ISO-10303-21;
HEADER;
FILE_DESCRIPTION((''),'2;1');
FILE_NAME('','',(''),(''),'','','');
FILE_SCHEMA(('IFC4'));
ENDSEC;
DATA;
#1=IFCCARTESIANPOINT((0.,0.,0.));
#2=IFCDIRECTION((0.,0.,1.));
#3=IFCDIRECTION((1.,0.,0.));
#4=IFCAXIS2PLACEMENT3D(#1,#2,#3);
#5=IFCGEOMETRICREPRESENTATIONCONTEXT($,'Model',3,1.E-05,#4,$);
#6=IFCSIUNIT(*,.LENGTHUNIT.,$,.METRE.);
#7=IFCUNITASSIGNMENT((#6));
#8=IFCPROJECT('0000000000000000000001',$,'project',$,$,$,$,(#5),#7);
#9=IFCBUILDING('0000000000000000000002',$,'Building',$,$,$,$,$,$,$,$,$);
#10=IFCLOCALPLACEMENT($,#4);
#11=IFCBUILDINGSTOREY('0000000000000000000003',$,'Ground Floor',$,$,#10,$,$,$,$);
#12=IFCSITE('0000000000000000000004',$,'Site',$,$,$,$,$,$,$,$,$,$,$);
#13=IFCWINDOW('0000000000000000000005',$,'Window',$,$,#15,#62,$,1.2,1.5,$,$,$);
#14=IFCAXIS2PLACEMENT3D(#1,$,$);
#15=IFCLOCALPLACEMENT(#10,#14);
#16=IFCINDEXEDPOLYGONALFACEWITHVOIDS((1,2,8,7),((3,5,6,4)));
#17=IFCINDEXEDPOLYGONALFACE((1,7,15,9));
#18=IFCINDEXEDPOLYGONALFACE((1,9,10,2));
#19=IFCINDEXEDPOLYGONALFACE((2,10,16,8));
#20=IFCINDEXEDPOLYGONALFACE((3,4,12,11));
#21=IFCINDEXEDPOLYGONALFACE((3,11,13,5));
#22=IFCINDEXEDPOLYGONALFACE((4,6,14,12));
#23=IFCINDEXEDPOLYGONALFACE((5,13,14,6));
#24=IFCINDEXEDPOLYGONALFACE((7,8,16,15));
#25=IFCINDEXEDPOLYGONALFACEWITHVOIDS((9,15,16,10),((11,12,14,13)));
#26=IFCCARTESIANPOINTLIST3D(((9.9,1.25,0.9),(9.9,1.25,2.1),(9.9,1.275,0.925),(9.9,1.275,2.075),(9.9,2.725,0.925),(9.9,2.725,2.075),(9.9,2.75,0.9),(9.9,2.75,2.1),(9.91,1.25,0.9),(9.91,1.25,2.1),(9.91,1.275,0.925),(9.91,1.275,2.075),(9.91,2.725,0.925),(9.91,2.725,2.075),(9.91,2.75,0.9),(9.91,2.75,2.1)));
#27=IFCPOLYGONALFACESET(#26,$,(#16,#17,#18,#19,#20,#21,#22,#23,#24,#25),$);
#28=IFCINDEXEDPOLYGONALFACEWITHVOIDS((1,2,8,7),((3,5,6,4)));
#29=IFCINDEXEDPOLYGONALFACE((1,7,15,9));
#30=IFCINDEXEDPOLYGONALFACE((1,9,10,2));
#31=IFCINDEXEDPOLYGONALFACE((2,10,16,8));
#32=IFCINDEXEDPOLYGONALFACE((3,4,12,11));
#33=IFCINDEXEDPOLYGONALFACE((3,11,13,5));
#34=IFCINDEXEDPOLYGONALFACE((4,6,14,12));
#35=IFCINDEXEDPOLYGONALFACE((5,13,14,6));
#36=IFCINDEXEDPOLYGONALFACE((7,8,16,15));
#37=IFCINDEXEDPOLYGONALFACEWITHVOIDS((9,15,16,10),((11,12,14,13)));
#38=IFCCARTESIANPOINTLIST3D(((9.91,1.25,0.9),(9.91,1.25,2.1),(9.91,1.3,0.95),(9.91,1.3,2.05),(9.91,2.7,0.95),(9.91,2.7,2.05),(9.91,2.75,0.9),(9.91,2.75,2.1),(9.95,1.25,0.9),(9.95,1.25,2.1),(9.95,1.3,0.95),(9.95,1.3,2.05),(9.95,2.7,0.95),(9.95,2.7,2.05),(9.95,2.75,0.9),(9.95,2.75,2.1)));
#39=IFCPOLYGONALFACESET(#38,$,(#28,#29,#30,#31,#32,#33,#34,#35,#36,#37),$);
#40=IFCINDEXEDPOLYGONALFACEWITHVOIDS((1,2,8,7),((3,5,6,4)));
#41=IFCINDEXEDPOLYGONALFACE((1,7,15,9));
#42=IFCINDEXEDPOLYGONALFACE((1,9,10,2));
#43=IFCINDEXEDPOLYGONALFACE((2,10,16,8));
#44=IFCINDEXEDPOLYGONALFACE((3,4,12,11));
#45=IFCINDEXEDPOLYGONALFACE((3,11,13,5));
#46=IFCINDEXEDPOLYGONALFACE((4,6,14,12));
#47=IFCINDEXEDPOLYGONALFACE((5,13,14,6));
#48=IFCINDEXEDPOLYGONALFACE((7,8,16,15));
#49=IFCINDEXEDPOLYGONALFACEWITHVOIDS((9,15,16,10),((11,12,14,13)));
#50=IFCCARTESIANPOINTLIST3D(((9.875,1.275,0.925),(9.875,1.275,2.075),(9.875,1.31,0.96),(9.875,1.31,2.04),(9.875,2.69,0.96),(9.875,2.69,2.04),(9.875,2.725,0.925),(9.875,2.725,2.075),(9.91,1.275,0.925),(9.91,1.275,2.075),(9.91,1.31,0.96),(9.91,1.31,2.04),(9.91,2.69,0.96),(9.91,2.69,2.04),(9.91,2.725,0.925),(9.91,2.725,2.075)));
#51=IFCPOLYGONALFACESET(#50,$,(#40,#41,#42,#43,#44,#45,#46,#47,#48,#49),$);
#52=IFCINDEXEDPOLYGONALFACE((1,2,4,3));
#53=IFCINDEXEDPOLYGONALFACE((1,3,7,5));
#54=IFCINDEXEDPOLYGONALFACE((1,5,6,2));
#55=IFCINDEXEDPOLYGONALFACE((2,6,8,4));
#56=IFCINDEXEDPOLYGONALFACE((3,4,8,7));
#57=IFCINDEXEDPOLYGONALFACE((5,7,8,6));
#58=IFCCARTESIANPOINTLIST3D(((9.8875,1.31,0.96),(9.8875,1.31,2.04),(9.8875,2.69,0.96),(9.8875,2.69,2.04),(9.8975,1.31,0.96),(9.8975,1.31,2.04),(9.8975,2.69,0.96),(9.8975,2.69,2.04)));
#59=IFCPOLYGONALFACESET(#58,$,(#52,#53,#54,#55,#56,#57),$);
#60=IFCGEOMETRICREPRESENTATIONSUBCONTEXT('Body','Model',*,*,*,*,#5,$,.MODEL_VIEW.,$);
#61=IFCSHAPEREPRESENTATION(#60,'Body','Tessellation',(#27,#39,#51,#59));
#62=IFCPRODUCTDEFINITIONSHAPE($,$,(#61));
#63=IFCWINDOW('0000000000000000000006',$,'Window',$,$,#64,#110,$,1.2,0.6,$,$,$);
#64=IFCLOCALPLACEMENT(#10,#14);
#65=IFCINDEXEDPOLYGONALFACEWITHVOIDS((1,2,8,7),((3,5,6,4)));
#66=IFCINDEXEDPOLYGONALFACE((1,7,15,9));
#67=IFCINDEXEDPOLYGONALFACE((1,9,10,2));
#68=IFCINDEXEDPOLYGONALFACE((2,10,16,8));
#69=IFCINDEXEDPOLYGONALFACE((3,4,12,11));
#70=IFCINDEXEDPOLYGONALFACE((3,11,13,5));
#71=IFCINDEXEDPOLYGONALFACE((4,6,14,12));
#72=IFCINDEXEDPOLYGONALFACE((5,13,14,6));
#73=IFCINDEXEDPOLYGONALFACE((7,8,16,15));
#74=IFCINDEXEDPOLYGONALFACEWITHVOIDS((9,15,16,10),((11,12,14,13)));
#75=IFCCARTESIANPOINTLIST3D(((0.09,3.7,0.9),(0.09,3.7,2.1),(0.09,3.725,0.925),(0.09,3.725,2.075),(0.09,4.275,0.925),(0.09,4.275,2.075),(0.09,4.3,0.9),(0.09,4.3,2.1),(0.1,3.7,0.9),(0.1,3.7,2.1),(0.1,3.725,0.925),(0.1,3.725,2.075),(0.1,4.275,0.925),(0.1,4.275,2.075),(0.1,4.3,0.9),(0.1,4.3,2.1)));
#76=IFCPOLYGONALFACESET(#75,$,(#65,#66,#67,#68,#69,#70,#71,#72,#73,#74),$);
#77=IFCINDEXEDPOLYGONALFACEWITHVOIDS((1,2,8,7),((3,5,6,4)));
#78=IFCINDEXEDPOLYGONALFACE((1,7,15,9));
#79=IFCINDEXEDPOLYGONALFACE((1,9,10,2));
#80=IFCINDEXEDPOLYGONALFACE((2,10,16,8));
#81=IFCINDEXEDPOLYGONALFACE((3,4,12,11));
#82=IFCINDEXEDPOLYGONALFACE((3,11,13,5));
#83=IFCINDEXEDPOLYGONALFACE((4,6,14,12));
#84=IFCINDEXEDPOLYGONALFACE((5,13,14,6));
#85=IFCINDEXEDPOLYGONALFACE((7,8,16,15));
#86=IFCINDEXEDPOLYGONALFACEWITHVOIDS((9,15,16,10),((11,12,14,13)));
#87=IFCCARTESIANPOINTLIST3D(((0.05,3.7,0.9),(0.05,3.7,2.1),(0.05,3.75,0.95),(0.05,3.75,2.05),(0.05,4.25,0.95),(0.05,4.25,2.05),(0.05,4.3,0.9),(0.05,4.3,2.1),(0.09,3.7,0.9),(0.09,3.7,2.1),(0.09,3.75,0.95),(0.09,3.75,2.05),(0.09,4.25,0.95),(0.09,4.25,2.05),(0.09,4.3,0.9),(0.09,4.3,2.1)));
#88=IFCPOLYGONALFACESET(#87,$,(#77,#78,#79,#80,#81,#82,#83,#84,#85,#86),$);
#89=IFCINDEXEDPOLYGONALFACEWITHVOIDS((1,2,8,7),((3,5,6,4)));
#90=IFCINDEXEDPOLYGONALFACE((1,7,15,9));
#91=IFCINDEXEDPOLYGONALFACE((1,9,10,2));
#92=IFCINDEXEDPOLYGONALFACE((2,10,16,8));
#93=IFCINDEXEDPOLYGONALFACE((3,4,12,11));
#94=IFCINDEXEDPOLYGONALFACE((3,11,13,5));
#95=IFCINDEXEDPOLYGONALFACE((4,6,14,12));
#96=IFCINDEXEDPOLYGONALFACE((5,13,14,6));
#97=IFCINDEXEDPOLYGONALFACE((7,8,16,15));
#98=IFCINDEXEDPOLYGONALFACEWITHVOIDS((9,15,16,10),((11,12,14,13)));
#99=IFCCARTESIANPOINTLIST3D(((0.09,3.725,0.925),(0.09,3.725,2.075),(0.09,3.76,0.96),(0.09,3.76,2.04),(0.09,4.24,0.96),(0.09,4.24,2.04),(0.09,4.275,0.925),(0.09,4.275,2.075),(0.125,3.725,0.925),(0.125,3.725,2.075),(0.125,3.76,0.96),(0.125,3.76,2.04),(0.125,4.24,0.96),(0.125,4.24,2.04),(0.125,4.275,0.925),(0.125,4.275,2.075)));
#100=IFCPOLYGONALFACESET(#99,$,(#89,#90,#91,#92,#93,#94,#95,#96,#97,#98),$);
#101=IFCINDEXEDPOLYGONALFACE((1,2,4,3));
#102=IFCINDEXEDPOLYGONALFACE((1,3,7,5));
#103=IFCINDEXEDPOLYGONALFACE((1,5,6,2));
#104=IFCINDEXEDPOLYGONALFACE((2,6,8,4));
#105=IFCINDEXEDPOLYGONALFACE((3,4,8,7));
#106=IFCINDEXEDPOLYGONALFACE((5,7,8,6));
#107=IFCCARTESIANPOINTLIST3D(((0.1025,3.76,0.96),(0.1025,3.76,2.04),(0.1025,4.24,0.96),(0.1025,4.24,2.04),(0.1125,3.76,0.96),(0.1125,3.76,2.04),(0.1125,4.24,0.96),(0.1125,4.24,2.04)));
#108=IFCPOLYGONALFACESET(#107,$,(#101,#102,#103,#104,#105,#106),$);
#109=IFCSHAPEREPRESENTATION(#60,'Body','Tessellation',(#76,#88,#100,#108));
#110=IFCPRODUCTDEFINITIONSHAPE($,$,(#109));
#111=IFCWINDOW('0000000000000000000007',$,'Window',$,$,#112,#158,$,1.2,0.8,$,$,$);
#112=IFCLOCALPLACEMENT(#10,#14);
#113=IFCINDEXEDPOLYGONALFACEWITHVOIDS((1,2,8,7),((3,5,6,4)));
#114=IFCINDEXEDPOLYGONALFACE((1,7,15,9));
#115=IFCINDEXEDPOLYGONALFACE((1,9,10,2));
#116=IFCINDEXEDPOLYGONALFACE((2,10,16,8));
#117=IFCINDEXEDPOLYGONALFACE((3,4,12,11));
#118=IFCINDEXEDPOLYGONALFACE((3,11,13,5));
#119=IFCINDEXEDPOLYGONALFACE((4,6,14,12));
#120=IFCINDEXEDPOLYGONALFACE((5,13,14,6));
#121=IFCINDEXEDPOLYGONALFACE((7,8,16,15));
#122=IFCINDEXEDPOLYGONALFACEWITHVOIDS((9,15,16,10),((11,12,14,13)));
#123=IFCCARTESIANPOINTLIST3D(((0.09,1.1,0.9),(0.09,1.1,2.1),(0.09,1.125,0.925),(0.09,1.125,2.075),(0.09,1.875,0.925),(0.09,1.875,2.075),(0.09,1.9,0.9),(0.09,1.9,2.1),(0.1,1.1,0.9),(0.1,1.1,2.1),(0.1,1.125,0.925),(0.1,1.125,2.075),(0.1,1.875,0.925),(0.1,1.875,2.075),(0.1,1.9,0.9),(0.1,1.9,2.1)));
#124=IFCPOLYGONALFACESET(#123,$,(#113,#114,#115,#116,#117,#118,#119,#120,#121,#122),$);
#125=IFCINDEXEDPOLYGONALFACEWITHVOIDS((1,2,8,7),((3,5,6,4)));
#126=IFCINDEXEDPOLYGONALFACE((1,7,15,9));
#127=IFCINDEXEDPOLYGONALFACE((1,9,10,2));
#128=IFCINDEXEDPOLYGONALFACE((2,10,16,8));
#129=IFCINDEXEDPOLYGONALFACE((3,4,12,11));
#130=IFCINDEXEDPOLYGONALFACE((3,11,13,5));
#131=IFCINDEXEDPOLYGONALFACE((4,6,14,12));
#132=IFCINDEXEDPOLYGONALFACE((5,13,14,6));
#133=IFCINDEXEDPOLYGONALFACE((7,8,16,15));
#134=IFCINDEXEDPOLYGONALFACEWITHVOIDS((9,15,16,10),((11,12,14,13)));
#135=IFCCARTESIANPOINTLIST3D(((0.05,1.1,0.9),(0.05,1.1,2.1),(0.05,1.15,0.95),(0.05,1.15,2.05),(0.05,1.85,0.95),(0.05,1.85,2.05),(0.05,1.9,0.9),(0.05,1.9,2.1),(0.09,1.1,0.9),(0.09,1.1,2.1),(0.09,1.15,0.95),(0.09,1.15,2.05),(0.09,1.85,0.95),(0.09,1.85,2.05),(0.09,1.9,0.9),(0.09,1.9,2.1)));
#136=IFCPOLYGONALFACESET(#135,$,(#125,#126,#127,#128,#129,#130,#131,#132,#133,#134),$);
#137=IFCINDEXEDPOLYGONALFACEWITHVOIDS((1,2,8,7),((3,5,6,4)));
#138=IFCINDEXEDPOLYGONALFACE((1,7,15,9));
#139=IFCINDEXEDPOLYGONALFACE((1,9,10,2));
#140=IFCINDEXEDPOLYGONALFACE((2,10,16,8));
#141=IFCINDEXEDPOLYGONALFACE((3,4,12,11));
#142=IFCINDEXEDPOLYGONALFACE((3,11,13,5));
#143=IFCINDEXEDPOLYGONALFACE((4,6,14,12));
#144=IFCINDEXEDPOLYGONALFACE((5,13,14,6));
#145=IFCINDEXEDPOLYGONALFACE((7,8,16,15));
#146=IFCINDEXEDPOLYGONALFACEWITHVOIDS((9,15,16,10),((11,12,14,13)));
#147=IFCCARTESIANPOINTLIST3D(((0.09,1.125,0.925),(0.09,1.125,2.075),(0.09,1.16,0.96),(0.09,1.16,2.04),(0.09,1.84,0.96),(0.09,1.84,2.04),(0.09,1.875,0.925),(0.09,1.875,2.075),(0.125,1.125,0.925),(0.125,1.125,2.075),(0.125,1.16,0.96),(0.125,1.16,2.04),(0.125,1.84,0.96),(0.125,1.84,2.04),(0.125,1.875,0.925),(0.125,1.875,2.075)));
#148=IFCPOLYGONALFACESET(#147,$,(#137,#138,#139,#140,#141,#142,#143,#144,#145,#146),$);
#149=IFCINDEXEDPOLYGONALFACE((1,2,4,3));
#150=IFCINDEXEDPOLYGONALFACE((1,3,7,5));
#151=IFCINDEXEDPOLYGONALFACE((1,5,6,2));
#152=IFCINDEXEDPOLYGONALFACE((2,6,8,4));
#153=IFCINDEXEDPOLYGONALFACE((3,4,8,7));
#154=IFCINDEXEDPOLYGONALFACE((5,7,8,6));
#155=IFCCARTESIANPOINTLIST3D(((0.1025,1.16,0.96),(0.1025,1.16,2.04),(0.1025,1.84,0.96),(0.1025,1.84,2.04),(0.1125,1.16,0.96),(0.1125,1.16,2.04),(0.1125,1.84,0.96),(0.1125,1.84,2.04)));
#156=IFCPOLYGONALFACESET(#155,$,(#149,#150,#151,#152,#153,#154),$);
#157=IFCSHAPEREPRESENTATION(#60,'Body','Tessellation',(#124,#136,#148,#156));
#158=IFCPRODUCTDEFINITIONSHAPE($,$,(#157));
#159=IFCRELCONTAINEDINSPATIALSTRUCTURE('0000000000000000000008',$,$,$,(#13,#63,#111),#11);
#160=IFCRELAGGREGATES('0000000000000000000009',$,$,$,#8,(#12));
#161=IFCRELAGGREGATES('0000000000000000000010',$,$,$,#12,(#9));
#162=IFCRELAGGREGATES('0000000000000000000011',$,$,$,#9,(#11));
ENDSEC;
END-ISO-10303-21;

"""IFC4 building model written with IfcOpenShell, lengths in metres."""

from ifc_helpers import new_model, si_unit, frame, origin_with_axes, place, context, subcontext, project, spatial, line, indexed_curve, outline, extrude, element, save


model = new_model("IFC4")

# Units and contexts
model_context = context("Model", 3, precision=1e-05, world=origin_with_axes())
body_context = subcontext(model_context, "Body", "Model", "MODEL_VIEW")
ifc_project = project(units=[si_unit("LENGTHUNIT", "METRE")], contexts=[model_context])

# Site, building, storey
site = spatial("IfcSite", under=ifc_project, Name="Site")
building = spatial("IfcBuilding", under=site, Name="Building")
storey_placement = place(None, origin_with_axes())
storey = spatial("IfcBuildingStorey", under=building, at=storey_placement, Name="Ground Floor")

# Windows
window_1_placement = place(storey_placement, frame((10.0, 1.25, 0.9), z_axis=(0.0, 0.0, 1.0), x_axis=(0.0, 1.0, 0.0)))
element("IfcWindow", 1, at=window_1_placement, inside=storey, Name="Window", OverallHeight=1.2, OverallWidth=1.5, context=body_context, shape_type="SweptSolid", body=[
    extrude(outline(indexed_curve([(0.0, 0.0), (1.5, 0.0), (1.5, 1.2), (0.0, 1.2)], segments=[line(1, 2, 3, 4, 1)]), holes=[indexed_curve([(0.025, 0.025), (1.475, 0.025), (1.475, 1.175), (0.025, 1.175)], segments=[line(1, 2, 3, 4, 1)])]), frame((0.0, 0.09, 0.0), z_axis=(0.0, -1.0, 0.0), x_axis=(1.0, 0.0, 0.0)), (0.0, 0.0, -1.0), 0.01),
    extrude(outline(indexed_curve([(0.0, 0.0), (1.5, 0.0), (1.5, 1.2), (0.0, 1.2)], segments=[line(1, 2, 3, 4, 1)]), holes=[indexed_curve([(0.05, 0.05), (1.45, 0.05), (1.45, 1.15), (0.05, 1.15)], segments=[line(1, 2, 3, 4, 1)])]), frame((0.0, 0.05, 0.0), z_axis=(0.0, -1.0, 0.0), x_axis=(1.0, 0.0, 0.0)), (0.0, 0.0, -1.0), 0.04),
    extrude(outline(indexed_curve([(0.0, 0.0), (1.45, 0.0), (1.45, 1.15), (0.0, 1.15)], segments=[line(1, 2, 3, 4, 1)]), holes=[indexed_curve([(0.035, 0.035), (1.415, 0.035), (1.415, 1.115), (0.035, 1.115)], segments=[line(1, 2, 3, 4, 1)])]), frame((0.025, 0.09, 0.025), z_axis=(0.0, -1.0, 0.0), x_axis=(1.0, 0.0, 0.0)), (0.0, 0.0, -1.0), 0.035),
    extrude(outline(indexed_curve([(0.035, 0.035), (1.415, 0.035), (1.415, 1.115), (0.035, 1.115)], segments=[line(1, 2, 3, 4, 1)])), frame((0.025, 0.1025, 0.025), z_axis=(0.0, -1.0, 0.0), x_axis=(1.0, 0.0, 0.0)), (0.0, 0.0, -1.0), 0.01),
])
window_2_placement = place(storey_placement, frame((0.0, 4.3, 0.9), z_axis=(0.0, 0.0, 1.0), x_axis=(0.0, -1.0, 0.0)))
element("IfcWindow", 2, at=window_2_placement, inside=storey, Name="Window", OverallHeight=1.2, OverallWidth=0.6, context=body_context, shape_type="SweptSolid", body=[
    extrude(outline(indexed_curve([(0.0, 0.0), (0.6, 0.0), (0.6, 1.2), (0.0, 1.2)], segments=[line(1, 2, 3, 4, 1)]), holes=[indexed_curve([(0.025, 0.025), (0.575, 0.025), (0.575, 1.175), (0.025, 1.175)], segments=[line(1, 2, 3, 4, 1)])]), frame((0.0, 0.09, 0.0), z_axis=(0.0, -1.0, 0.0), x_axis=(1.0, 0.0, 0.0)), (0.0, 0.0, -1.0), 0.01),
    extrude(outline(indexed_curve([(0.0, 0.0), (0.6, 0.0), (0.6, 1.2), (0.0, 1.2)], segments=[line(1, 2, 3, 4, 1)]), holes=[indexed_curve([(0.05, 0.05), (0.55, 0.05), (0.55, 1.15), (0.05, 1.15)], segments=[line(1, 2, 3, 4, 1)])]), frame((0.0, 0.05, 0.0), z_axis=(0.0, -1.0, 0.0), x_axis=(1.0, 0.0, 0.0)), (0.0, 0.0, -1.0), 0.04),
    extrude(outline(indexed_curve([(0.0, 0.0), (0.55, 0.0), (0.55, 1.15), (0.0, 1.15)], segments=[line(1, 2, 3, 4, 1)]), holes=[indexed_curve([(0.035, 0.035), (0.515, 0.035), (0.515, 1.115), (0.035, 1.115)], segments=[line(1, 2, 3, 4, 1)])]), frame((0.025, 0.09, 0.025), z_axis=(0.0, -1.0, 0.0), x_axis=(1.0, 0.0, 0.0)), (0.0, 0.0, -1.0), 0.035),
    extrude(outline(indexed_curve([(0.035, 0.035), (0.515, 0.035), (0.515, 1.115), (0.035, 1.115)], segments=[line(1, 2, 3, 4, 1)])), frame((0.025, 0.1025, 0.025), z_axis=(0.0, -1.0, 0.0), x_axis=(1.0, 0.0, 0.0)), (0.0, 0.0, -1.0), 0.01),
])
window_3_placement = place(storey_placement, frame((0.0, 1.9, 0.9), z_axis=(0.0, 0.0, 1.0), x_axis=(0.0, -1.0, 0.0)))
element("IfcWindow", 3, at=window_3_placement, inside=storey, Name="Window", OverallHeight=1.2, OverallWidth=0.8, context=body_context, shape_type="SweptSolid", body=[
    extrude(outline(indexed_curve([(0.0, 0.0), (0.8, 0.0), (0.8, 1.2), (0.0, 1.2)], segments=[line(1, 2, 3, 4, 1)]), holes=[indexed_curve([(0.025, 0.025), (0.775, 0.025), (0.775, 1.175), (0.025, 1.175)], segments=[line(1, 2, 3, 4, 1)])]), frame((0.0, 0.09, 0.0), z_axis=(0.0, -1.0, 0.0), x_axis=(1.0, 0.0, 0.0)), (0.0, 0.0, -1.0), 0.01),
    extrude(outline(indexed_curve([(0.0, 0.0), (0.8, 0.0), (0.8, 1.2), (0.0, 1.2)], segments=[line(1, 2, 3, 4, 1)]), holes=[indexed_curve([(0.05, 0.05), (0.75, 0.05), (0.75, 1.15), (0.05, 1.15)], segments=[line(1, 2, 3, 4, 1)])]), frame((0.0, 0.05, 0.0), z_axis=(0.0, -1.0, 0.0), x_axis=(1.0, 0.0, 0.0)), (0.0, 0.0, -1.0), 0.04),
    extrude(outline(indexed_curve([(0.0, 0.0), (0.75, 0.0), (0.75, 1.15), (0.0, 1.15)], segments=[line(1, 2, 3, 4, 1)]), holes=[indexed_curve([(0.035, 0.035), (0.715, 0.035), (0.715, 1.115), (0.035, 1.115)], segments=[line(1, 2, 3, 4, 1)])]), frame((0.025, 0.09, 0.025), z_axis=(0.0, -1.0, 0.0), x_axis=(1.0, 0.0, 0.0)), (0.0, 0.0, -1.0), 0.035),
    extrude(outline(indexed_curve([(0.035, 0.035), (0.715, 0.035), (0.715, 1.115), (0.035, 1.115)], segments=[line(1, 2, 3, 4, 1)])), frame((0.025, 0.1025, 0.025), z_axis=(0.0, -1.0, 0.0), x_axis=(1.0, 0.0, 0.0)), (0.0, 0.0, -1.0), 0.01),
])

save(model, "model.ifc")
